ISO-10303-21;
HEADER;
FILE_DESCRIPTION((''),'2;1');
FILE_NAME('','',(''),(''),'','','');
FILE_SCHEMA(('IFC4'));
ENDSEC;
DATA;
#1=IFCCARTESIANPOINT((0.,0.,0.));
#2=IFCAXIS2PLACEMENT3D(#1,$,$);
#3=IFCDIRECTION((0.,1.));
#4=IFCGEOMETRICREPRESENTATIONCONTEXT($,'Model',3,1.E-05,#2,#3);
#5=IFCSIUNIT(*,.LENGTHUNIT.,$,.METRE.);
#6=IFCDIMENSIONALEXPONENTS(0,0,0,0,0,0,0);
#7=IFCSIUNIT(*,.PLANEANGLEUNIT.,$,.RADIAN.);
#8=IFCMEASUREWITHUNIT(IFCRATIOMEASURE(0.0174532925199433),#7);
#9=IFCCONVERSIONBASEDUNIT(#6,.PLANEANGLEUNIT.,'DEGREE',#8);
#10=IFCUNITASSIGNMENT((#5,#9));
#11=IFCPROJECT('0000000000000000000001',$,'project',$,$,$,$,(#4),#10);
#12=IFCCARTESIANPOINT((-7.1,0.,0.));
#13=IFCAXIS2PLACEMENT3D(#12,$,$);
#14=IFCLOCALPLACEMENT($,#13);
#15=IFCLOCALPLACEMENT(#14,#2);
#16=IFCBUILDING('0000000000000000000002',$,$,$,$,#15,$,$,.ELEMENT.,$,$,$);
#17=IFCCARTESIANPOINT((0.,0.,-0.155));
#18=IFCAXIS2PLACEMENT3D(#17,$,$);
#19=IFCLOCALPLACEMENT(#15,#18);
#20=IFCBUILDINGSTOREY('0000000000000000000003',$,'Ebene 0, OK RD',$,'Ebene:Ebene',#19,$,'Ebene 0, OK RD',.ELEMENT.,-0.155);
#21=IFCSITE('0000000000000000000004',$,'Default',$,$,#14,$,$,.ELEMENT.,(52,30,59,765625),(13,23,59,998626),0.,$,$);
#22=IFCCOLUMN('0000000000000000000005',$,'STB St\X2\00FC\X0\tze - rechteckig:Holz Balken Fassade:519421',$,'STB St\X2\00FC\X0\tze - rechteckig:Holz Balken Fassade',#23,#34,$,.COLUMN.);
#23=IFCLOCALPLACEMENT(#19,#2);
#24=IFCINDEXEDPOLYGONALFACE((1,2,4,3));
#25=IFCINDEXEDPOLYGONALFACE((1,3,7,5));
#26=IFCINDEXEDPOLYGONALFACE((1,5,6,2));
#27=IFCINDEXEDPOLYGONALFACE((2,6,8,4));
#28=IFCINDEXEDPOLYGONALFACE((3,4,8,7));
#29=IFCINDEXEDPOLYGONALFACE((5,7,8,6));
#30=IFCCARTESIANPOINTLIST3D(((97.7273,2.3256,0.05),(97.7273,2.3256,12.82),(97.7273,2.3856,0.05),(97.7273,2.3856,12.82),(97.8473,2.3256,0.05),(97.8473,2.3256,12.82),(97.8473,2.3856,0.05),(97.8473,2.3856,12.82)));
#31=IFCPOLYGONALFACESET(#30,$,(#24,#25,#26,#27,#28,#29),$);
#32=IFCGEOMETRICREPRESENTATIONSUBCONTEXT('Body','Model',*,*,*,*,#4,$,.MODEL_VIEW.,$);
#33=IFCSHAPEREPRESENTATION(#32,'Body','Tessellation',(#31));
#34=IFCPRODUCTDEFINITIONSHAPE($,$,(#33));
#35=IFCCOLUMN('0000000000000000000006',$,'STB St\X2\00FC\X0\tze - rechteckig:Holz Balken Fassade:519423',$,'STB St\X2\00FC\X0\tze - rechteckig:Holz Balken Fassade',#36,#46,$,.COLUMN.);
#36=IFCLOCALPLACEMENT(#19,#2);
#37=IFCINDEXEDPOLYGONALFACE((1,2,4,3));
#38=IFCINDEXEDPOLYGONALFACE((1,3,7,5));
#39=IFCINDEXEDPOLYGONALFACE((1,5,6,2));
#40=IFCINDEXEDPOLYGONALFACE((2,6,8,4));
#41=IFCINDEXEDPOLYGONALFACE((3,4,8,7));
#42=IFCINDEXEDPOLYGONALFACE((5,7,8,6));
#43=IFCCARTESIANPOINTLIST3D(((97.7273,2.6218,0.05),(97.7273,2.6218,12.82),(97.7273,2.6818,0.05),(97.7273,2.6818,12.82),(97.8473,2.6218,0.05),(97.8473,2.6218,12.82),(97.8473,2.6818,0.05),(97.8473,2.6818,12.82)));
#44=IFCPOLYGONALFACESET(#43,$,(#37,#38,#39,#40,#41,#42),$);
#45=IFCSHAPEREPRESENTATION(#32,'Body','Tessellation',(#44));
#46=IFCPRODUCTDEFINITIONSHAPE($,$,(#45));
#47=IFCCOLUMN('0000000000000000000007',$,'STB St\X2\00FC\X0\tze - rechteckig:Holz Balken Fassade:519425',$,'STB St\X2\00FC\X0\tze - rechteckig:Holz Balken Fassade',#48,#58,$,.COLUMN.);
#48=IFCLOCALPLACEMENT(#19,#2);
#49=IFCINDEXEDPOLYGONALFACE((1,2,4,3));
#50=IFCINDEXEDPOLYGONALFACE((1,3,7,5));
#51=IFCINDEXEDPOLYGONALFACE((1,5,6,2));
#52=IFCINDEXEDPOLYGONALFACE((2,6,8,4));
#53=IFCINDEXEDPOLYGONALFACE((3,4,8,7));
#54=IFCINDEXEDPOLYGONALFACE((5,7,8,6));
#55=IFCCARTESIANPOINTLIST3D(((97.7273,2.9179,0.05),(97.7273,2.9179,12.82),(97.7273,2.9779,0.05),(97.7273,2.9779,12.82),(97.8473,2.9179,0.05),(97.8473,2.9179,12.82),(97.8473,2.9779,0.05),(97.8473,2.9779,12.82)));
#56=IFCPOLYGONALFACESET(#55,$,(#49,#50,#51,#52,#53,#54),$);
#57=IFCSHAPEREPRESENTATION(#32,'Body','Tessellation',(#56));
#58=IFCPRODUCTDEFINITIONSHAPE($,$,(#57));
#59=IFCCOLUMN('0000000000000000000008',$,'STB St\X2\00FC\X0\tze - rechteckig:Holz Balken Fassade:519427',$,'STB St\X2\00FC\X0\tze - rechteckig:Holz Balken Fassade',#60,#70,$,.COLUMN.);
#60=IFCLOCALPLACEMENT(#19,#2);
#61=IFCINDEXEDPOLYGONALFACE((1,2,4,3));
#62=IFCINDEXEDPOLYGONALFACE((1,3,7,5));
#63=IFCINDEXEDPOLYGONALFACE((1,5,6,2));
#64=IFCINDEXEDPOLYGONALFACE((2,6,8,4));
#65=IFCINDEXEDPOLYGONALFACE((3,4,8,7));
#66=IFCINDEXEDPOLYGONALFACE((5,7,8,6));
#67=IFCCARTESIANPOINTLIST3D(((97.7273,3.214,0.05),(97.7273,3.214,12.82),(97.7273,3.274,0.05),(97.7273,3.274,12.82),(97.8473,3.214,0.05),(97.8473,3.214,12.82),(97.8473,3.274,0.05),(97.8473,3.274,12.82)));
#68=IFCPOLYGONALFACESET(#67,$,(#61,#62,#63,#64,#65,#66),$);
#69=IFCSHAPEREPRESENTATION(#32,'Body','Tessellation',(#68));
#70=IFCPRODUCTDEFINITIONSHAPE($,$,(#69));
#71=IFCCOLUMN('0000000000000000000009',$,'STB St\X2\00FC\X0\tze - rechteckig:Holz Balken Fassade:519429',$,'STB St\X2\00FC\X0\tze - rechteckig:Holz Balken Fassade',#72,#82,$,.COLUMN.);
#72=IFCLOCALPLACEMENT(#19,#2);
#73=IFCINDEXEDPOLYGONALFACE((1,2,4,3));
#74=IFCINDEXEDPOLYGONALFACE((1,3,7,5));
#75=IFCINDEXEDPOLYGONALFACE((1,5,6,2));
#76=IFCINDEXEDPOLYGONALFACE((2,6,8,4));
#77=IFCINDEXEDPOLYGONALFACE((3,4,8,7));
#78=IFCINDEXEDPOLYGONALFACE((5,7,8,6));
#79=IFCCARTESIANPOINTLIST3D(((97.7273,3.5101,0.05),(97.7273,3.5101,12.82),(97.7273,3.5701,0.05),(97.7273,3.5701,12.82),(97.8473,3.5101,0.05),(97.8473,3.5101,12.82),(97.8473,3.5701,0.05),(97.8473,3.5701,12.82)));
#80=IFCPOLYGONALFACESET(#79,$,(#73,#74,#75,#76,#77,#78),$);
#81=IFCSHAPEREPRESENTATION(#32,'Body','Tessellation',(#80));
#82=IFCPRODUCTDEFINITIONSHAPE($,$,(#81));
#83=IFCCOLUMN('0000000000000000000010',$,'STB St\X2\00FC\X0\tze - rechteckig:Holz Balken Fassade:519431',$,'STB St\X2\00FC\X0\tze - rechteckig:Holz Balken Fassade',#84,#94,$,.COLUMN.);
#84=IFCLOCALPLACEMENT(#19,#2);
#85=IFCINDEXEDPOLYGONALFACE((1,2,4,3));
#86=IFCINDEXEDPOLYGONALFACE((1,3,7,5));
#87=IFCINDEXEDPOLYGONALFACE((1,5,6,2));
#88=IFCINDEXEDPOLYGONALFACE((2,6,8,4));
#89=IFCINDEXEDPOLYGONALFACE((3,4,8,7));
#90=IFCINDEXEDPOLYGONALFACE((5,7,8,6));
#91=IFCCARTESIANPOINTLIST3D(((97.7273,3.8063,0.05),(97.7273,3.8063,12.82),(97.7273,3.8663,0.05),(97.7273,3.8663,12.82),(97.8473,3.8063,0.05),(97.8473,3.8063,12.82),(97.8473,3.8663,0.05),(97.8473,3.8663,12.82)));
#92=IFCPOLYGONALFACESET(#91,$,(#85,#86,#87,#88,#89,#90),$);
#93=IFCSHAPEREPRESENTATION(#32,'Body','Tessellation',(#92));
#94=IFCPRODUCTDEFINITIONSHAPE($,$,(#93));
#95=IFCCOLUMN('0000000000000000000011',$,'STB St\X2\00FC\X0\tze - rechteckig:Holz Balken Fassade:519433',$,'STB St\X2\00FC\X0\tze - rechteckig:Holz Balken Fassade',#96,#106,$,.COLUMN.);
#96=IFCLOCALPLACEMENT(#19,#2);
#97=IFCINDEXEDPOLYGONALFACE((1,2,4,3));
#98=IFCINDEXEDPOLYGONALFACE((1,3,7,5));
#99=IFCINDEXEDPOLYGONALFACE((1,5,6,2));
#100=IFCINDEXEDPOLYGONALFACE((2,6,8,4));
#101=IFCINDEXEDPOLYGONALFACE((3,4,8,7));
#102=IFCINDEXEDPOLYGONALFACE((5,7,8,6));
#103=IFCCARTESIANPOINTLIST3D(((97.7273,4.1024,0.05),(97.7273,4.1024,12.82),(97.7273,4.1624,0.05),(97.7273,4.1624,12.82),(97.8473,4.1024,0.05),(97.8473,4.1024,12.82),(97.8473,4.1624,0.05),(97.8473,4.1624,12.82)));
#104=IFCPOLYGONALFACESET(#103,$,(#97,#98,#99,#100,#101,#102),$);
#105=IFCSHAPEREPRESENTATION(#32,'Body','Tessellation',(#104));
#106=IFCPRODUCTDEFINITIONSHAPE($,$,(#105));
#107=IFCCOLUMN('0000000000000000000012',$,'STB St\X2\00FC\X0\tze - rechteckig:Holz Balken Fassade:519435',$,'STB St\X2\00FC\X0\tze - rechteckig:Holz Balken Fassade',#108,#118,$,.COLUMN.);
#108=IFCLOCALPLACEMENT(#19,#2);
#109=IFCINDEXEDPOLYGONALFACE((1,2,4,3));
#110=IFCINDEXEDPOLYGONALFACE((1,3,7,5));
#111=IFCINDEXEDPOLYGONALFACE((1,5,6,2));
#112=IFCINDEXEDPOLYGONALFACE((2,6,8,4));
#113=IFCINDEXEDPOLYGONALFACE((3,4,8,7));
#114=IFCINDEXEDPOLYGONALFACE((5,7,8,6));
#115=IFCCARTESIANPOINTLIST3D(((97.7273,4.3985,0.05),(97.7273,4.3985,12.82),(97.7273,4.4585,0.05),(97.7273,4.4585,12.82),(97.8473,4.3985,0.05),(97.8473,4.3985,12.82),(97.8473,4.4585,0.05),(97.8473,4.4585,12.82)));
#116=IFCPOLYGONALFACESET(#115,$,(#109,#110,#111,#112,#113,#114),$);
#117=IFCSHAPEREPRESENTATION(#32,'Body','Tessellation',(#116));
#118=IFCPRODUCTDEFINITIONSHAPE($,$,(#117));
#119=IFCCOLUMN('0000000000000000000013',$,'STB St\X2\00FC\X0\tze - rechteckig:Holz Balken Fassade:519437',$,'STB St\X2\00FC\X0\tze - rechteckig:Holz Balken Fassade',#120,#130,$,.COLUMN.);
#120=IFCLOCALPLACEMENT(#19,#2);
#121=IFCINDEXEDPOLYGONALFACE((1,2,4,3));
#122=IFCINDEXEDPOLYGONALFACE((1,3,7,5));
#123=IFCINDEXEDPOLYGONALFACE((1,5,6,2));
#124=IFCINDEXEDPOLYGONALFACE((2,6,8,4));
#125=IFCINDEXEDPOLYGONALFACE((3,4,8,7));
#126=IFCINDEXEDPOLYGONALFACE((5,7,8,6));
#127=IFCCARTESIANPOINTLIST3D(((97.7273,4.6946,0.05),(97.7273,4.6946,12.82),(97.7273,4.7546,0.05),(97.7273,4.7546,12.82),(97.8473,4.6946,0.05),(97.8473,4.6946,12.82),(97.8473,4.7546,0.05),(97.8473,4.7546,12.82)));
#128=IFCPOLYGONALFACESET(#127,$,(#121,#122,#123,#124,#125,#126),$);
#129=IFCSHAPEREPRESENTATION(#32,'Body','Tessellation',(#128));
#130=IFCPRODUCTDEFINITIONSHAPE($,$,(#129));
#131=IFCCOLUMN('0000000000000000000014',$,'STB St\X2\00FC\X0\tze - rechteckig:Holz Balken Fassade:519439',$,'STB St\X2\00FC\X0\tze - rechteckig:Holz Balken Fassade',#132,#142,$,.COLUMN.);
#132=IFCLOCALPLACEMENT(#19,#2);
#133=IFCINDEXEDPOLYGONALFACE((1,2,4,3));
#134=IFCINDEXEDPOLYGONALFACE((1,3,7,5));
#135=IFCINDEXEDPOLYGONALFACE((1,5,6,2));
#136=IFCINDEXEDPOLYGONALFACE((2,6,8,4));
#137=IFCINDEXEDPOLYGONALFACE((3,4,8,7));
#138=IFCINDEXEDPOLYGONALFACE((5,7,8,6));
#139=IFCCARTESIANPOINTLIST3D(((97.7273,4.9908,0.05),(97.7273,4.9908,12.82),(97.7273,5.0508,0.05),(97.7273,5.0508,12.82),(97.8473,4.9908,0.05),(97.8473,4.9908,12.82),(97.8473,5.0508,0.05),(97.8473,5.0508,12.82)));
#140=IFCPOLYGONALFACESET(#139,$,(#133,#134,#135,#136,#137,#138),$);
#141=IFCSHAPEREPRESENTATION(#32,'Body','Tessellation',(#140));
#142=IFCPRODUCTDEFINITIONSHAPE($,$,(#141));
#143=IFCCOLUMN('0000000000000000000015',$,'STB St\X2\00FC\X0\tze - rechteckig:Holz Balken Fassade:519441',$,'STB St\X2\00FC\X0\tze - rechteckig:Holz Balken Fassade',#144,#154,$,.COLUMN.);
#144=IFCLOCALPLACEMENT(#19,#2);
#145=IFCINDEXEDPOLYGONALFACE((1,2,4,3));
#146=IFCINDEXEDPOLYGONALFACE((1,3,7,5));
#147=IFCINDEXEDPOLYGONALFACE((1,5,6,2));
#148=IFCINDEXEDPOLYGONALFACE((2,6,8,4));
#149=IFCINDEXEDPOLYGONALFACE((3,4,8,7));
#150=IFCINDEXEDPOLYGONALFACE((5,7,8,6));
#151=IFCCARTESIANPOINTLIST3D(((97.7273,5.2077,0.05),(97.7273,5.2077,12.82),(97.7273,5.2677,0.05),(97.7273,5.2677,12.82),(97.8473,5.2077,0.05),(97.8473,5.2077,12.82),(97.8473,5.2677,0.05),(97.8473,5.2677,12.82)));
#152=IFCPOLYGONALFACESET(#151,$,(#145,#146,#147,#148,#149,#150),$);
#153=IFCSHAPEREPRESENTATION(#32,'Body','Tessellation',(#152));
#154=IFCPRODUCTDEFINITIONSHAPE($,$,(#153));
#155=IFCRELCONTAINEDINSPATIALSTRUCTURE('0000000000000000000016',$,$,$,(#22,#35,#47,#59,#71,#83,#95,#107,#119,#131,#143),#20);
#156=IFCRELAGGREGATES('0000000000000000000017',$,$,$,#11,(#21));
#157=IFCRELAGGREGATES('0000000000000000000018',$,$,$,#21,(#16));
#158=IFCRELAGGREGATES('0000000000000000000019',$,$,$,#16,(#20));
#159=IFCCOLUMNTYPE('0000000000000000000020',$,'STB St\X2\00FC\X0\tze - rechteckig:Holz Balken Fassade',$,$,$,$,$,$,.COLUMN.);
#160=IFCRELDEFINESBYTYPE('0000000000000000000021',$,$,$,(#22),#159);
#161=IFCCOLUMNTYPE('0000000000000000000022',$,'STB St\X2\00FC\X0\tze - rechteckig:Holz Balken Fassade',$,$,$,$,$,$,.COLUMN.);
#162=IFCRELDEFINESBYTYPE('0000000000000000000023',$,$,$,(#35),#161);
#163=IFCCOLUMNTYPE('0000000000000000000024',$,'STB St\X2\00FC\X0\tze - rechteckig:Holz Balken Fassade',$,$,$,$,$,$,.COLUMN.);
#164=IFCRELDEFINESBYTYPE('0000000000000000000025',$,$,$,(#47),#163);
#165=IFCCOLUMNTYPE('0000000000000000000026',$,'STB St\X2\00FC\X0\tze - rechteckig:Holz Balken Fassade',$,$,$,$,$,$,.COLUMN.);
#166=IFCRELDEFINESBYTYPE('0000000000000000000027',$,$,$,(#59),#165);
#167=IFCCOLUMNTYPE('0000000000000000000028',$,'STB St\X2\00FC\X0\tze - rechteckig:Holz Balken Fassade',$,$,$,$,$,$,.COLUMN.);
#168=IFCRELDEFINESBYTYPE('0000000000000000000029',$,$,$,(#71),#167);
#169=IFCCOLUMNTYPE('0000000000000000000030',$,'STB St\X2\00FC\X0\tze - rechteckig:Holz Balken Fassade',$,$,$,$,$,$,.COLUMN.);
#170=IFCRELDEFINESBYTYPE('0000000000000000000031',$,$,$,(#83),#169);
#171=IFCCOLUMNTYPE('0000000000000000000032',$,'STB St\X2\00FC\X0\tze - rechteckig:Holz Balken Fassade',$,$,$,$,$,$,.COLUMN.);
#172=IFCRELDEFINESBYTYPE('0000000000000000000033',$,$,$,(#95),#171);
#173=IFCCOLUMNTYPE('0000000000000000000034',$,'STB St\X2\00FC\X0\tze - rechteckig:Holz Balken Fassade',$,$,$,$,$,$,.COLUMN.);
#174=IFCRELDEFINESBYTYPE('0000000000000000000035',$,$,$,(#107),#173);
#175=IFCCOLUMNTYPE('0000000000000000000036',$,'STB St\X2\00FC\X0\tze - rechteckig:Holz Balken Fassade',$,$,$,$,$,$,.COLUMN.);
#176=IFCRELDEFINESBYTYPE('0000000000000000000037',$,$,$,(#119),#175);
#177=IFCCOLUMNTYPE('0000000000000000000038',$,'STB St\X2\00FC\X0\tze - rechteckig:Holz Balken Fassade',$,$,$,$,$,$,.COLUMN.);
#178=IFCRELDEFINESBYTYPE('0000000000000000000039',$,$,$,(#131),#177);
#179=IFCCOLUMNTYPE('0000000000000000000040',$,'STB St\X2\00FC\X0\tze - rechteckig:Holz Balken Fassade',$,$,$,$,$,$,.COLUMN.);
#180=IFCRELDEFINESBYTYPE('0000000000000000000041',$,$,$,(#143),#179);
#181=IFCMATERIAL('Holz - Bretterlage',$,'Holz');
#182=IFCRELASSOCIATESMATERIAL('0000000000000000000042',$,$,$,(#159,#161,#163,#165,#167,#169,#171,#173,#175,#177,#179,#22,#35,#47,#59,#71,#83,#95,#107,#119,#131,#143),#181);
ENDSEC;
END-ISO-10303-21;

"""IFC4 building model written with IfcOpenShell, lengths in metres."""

from ifc_helpers import new_model, entity, si_unit, converted_unit, direction, frame, frame_2d, origin, origin_2d_with_axis, place, context, subcontext, project, spatial, rectangle, extrude, source, transform, mapped, material, material_profile, profile_set, profile_usage, type_object, type_shapes, element, save


model = new_model("IFC4")

# Units and contexts
model_context = context("Model", 3, precision=1e-05, world=origin(), true_north=direction((0.0, 1.0)))
body_context = subcontext(model_context, "Body", "Model", "MODEL_VIEW")
ifc_project = project(units=[si_unit("LENGTHUNIT", "METRE"), converted_unit("PLANEANGLEUNIT", "DEGREE", entity("IfcRatioMeasure", 0.0174532925199433), si_unit("PLANEANGLEUNIT", "RADIAN"), dimensions=[0, 0, 0, 0, 0, 0, 0])], contexts=[model_context])

# Site, building, storey
site_placement = place(None, frame((-7.1, 0.0, 0.0)))
site = spatial("IfcSite", under=ifc_project, at=site_placement, Name="Default", CompositionType="ELEMENT", RefLatitude=(52, 30, 59, 765625), RefLongitude=(13, 23, 59, 998626), RefElevation=0.0)
building_placement = place(site_placement, origin())
building = spatial("IfcBuilding", under=site, at=building_placement, CompositionType="ELEMENT")
storey_placement = place(building_placement, frame((0.0, 0.0, -0.155)))
storey = spatial("IfcBuildingStorey", under=building, at=storey_placement, Name="Ebene 0, OK RD", ObjectType="Ebene:Ebene", LongName="Ebene 0, OK RD", CompositionType="ELEMENT", Elevation=-0.155)

# Columns
ifc_material_1 = material(Name="Holz - Bretterlage", Category="Holz")
ifc_material_profile = material_profile(ifc_material_1, rectangle(XDim=0.12, YDim=0.06, at=frame_2d((0.0, 0.0), x_axis=(1.0, 0.0))), Name="Holz Balken Fassade")
ifc_profile_set = profile_set([ifc_material_profile], Name="Holz Balken Fassade")
ifc_profile_usage_1 = profile_usage(ifc_profile_set)
column_type_1 = type_object("IfcColumnType", Name="STB Stütze - rechteckig:Holz Balken Fassade", PredefinedType="COLUMN", material=ifc_profile_set)
shared_shape_1 = source(origin(), body_context, "Body", "SweptSolid", [
    extrude(rectangle(XDim=0.06, YDim=0.12, at=frame_2d((0.0, 0.0), x_axis=(1.0, 0.0))), frame((97.7873, 2.3556, -0.105), z_axis=(0.0, 0.0, 1.0), x_axis=(0.0, -1.0, 0.0)), (0.0, 0.0, 1.0), 12.77),
])
type_shapes(column_type_1, [shared_shape_1])
column_1_placement = place(storey_placement, frame((0.0, 0.0, 0.155)))
element("IfcColumn", 1, at=column_1_placement, inside=storey, type_object=column_type_1, material=ifc_profile_usage_1, Name="STB Stütze - rechteckig:Holz Balken Fassade:519421", ObjectType="STB Stütze - rechteckig:Holz Balken Fassade", PredefinedType="COLUMN", context=body_context, shape_type="MappedRepresentation", body=[
    mapped(shared_shape_1, transform((0.0, 0.0, 0.0), scale=1.0)),
])
ifc_profile_usage_2 = profile_usage(ifc_profile_set)
column_type_2 = type_object("IfcColumnType", Name="STB Stütze - rechteckig:Holz Balken Fassade", PredefinedType="COLUMN", material=ifc_profile_set)
shared_shape_2 = source(origin(), body_context, "Body", "SweptSolid", [
    extrude(rectangle(XDim=0.06, YDim=0.12, at=frame_2d((0.0, 0.0), x_axis=(1.0, 0.0))), frame((97.7873, 2.6518, -0.105), z_axis=(0.0, 0.0, 1.0), x_axis=(0.0, -1.0, 0.0)), (0.0, 0.0, 1.0), 12.77),
])
type_shapes(column_type_2, [shared_shape_2])
column_2_placement = place(storey_placement, frame((0.0, 0.0, 0.155)))
element("IfcColumn", 2, at=column_2_placement, inside=storey, type_object=column_type_2, material=ifc_profile_usage_2, Name="STB Stütze - rechteckig:Holz Balken Fassade:519423", ObjectType="STB Stütze - rechteckig:Holz Balken Fassade", PredefinedType="COLUMN", context=body_context, shape_type="MappedRepresentation", body=[
    mapped(shared_shape_2, transform((0.0, 0.0, 0.0), scale=1.0)),
])
ifc_profile_usage_3 = profile_usage(ifc_profile_set)
column_type_3 = type_object("IfcColumnType", Name="STB Stütze - rechteckig:Holz Balken Fassade", PredefinedType="COLUMN", material=ifc_profile_set)
shared_shape_3 = source(origin(), body_context, "Body", "SweptSolid", [
    extrude(rectangle(XDim=0.06, YDim=0.12, at=frame_2d((0.0, 0.0), x_axis=(1.0, 0.0))), frame((97.7873, 2.9479, -0.105), z_axis=(0.0, 0.0, 1.0), x_axis=(0.0, -1.0, 0.0)), (0.0, 0.0, 1.0), 12.77),
])
type_shapes(column_type_3, [shared_shape_3])
column_3_placement = place(storey_placement, frame((0.0, 0.0, 0.155)))
element("IfcColumn", 3, at=column_3_placement, inside=storey, type_object=column_type_3, material=ifc_profile_usage_3, Name="STB Stütze - rechteckig:Holz Balken Fassade:519425", ObjectType="STB Stütze - rechteckig:Holz Balken Fassade", PredefinedType="COLUMN", context=body_context, shape_type="MappedRepresentation", body=[
    mapped(shared_shape_3, transform((0.0, 0.0, 0.0), scale=1.0)),
])
ifc_profile_usage_4 = profile_usage(ifc_profile_set)
column_type_4 = type_object("IfcColumnType", Name="STB Stütze - rechteckig:Holz Balken Fassade", PredefinedType="COLUMN", material=ifc_profile_set)
shared_shape_4 = source(origin(), body_context, "Body", "SweptSolid", [
    extrude(rectangle(XDim=0.06, YDim=0.12, at=frame_2d((0.0, 0.0), x_axis=(1.0, 0.0))), frame((97.7873, 3.244, -0.105), z_axis=(0.0, 0.0, 1.0), x_axis=(0.0, -1.0, 0.0)), (0.0, 0.0, 1.0), 12.77),
])
type_shapes(column_type_4, [shared_shape_4])
column_4_placement = place(storey_placement, frame((0.0, 0.0, 0.155)))
element("IfcColumn", 4, at=column_4_placement, inside=storey, type_object=column_type_4, material=ifc_profile_usage_4, Name="STB Stütze - rechteckig:Holz Balken Fassade:519427", ObjectType="STB Stütze - rechteckig:Holz Balken Fassade", PredefinedType="COLUMN", context=body_context, shape_type="MappedRepresentation", body=[
    mapped(shared_shape_4, transform((0.0, 0.0, 0.0), scale=1.0)),
])
ifc_profile_usage_5 = profile_usage(ifc_profile_set)
column_type_5 = type_object("IfcColumnType", Name="STB Stütze - rechteckig:Holz Balken Fassade", PredefinedType="COLUMN", material=ifc_profile_set)
shared_shape_5 = source(origin(), body_context, "Body", "SweptSolid", [
    extrude(rectangle(XDim=0.06, YDim=0.12, at=frame_2d((0.0, 0.0), x_axis=(1.0, 0.0))), frame((97.7873, 3.5401, -0.105), z_axis=(0.0, 0.0, 1.0), x_axis=(0.0, -1.0, 0.0)), (0.0, 0.0, 1.0), 12.77),
])
type_shapes(column_type_5, [shared_shape_5])
column_5_placement = place(storey_placement, frame((0.0, 0.0, 0.155)))
element("IfcColumn", 5, at=column_5_placement, inside=storey, type_object=column_type_5, material=ifc_profile_usage_5, Name="STB Stütze - rechteckig:Holz Balken Fassade:519429", ObjectType="STB Stütze - rechteckig:Holz Balken Fassade", PredefinedType="COLUMN", context=body_context, shape_type="MappedRepresentation", body=[
    mapped(shared_shape_5, transform((0.0, 0.0, 0.0), scale=1.0)),
])
ifc_profile_usage_6 = profile_usage(ifc_profile_set)
column_type_6 = type_object("IfcColumnType", Name="STB Stütze - rechteckig:Holz Balken Fassade", PredefinedType="COLUMN", material=ifc_profile_set)
shared_shape_6 = source(origin(), body_context, "Body", "SweptSolid", [
    extrude(rectangle(XDim=0.06, YDim=0.12, at=frame_2d((0.0, 0.0), x_axis=(1.0, 0.0))), frame((97.7873, 3.8363, -0.105), z_axis=(0.0, 0.0, 1.0), x_axis=(0.0, -1.0, 0.0)), (0.0, 0.0, 1.0), 12.77),
])
type_shapes(column_type_6, [shared_shape_6])
column_6_placement = place(storey_placement, frame((0.0, 0.0, 0.155)))
element("IfcColumn", 6, at=column_6_placement, inside=storey, type_object=column_type_6, material=ifc_profile_usage_6, Name="STB Stütze - rechteckig:Holz Balken Fassade:519431", ObjectType="STB Stütze - rechteckig:Holz Balken Fassade", PredefinedType="COLUMN", context=body_context, shape_type="MappedRepresentation", body=[
    mapped(shared_shape_6, transform((0.0, 0.0, 0.0), scale=1.0)),
])
ifc_profile_usage_7 = profile_usage(ifc_profile_set)
column_type_7 = type_object("IfcColumnType", Name="STB Stütze - rechteckig:Holz Balken Fassade", PredefinedType="COLUMN", material=ifc_profile_set)
shared_shape_7 = source(origin(), body_context, "Body", "SweptSolid", [
    extrude(rectangle(XDim=0.06, YDim=0.12, at=frame_2d((0.0, 0.0), x_axis=(1.0, 0.0))), frame((97.7873, 4.1324, -0.105), z_axis=(0.0, 0.0, 1.0), x_axis=(0.0, -1.0, 0.0)), (0.0, 0.0, 1.0), 12.77),
])
type_shapes(column_type_7, [shared_shape_7])
column_7_placement = place(storey_placement, frame((0.0, 0.0, 0.155)))
element("IfcColumn", 7, at=column_7_placement, inside=storey, type_object=column_type_7, material=ifc_profile_usage_7, Name="STB Stütze - rechteckig:Holz Balken Fassade:519433", ObjectType="STB Stütze - rechteckig:Holz Balken Fassade", PredefinedType="COLUMN", context=body_context, shape_type="MappedRepresentation", body=[
    mapped(shared_shape_7, transform((0.0, 0.0, 0.0), scale=1.0)),
])
ifc_profile_usage_8 = profile_usage(ifc_profile_set)
column_type_8 = type_object("IfcColumnType", Name="STB Stütze - rechteckig:Holz Balken Fassade", PredefinedType="COLUMN", material=ifc_profile_set)
shared_shape_8 = source(origin(), body_context, "Body", "SweptSolid", [
    extrude(rectangle(XDim=0.06, YDim=0.12, at=frame_2d((0.0, 0.0), x_axis=(1.0, 0.0))), frame((97.7873, 4.4285, -0.105), z_axis=(0.0, 0.0, 1.0), x_axis=(0.0, -1.0, 0.0)), (0.0, 0.0, 1.0), 12.77),
])
type_shapes(column_type_8, [shared_shape_8])
column_8_placement = place(storey_placement, frame((0.0, 0.0, 0.155)))
element("IfcColumn", 8, at=column_8_placement, inside=storey, type_object=column_type_8, material=ifc_profile_usage_8, Name="STB Stütze - rechteckig:Holz Balken Fassade:519435", ObjectType="STB Stütze - rechteckig:Holz Balken Fassade", PredefinedType="COLUMN", context=body_context, shape_type="MappedRepresentation", body=[
    mapped(shared_shape_8, transform((0.0, 0.0, 0.0), scale=1.0)),
])
ifc_profile_usage_9 = profile_usage(ifc_profile_set)
column_type_9 = type_object("IfcColumnType", Name="STB Stütze - rechteckig:Holz Balken Fassade", PredefinedType="COLUMN", material=ifc_profile_set)
shared_shape_9 = source(origin(), body_context, "Body", "SweptSolid", [
    extrude(rectangle(XDim=0.06, YDim=0.12, at=frame_2d((0.0, 0.0), x_axis=(1.0, 0.0))), frame((97.7873, 4.7246, -0.105), z_axis=(0.0, 0.0, 1.0), x_axis=(0.0, -1.0, 0.0)), (0.0, 0.0, 1.0), 12.77),
])
type_shapes(column_type_9, [shared_shape_9])
column_9_placement = place(storey_placement, frame((0.0, 0.0, 0.155)))
element("IfcColumn", 9, at=column_9_placement, inside=storey, type_object=column_type_9, material=ifc_profile_usage_9, Name="STB Stütze - rechteckig:Holz Balken Fassade:519437", ObjectType="STB Stütze - rechteckig:Holz Balken Fassade", PredefinedType="COLUMN", context=body_context, shape_type="MappedRepresentation", body=[
    mapped(shared_shape_9, transform((0.0, 0.0, 0.0), scale=1.0)),
])
ifc_profile_usage_10 = profile_usage(ifc_profile_set)
column_type_10 = type_object("IfcColumnType", Name="STB Stütze - rechteckig:Holz Balken Fassade", PredefinedType="COLUMN", material=ifc_profile_set)
shared_shape_10 = source(origin(), body_context, "Body", "SweptSolid", [
    extrude(rectangle(XDim=0.06, YDim=0.12, at=origin_2d_with_axis()), frame((97.7873, 5.0208, -0.105), z_axis=(0.0, 0.0, 1.0), x_axis=(0.0, -1.0, 0.0)), (0.0, 0.0, 1.0), 12.77),
])
type_shapes(column_type_10, [shared_shape_10])
column_10_placement = place(storey_placement, frame((0.0, 0.0, 0.155)))
element("IfcColumn", 10, at=column_10_placement, inside=storey, type_object=column_type_10, material=ifc_profile_usage_10, Name="STB Stütze - rechteckig:Holz Balken Fassade:519439", ObjectType="STB Stütze - rechteckig:Holz Balken Fassade", PredefinedType="COLUMN", context=body_context, shape_type="MappedRepresentation", body=[
    mapped(shared_shape_10, transform((0.0, 0.0, 0.0), scale=1.0)),
])
ifc_profile_usage_11 = profile_usage(ifc_profile_set)
column_type_11 = type_object("IfcColumnType", Name="STB Stütze - rechteckig:Holz Balken Fassade", PredefinedType="COLUMN", material=ifc_profile_set)
shared_shape_11 = source(origin(), body_context, "Body", "SweptSolid", [
    extrude(rectangle(XDim=0.06, YDim=0.12, at=origin_2d_with_axis()), frame((97.7873, 5.2377, -0.105), z_axis=(0.0, 0.0, 1.0), x_axis=(0.0, -1.0, 0.0)), (0.0, 0.0, 1.0), 12.77),
])
type_shapes(column_type_11, [shared_shape_11])
column_11_placement = place(storey_placement, frame((0.0, 0.0, 0.155)))
element("IfcColumn", 11, at=column_11_placement, inside=storey, type_object=column_type_11, material=ifc_profile_usage_11, Name="STB Stütze - rechteckig:Holz Balken Fassade:519441", ObjectType="STB Stütze - rechteckig:Holz Balken Fassade", PredefinedType="COLUMN", context=body_context, shape_type="MappedRepresentation", body=[
    mapped(shared_shape_11, transform((0.0, 0.0, 0.0), scale=1.0)),
])

save(model, "model.ifc")
